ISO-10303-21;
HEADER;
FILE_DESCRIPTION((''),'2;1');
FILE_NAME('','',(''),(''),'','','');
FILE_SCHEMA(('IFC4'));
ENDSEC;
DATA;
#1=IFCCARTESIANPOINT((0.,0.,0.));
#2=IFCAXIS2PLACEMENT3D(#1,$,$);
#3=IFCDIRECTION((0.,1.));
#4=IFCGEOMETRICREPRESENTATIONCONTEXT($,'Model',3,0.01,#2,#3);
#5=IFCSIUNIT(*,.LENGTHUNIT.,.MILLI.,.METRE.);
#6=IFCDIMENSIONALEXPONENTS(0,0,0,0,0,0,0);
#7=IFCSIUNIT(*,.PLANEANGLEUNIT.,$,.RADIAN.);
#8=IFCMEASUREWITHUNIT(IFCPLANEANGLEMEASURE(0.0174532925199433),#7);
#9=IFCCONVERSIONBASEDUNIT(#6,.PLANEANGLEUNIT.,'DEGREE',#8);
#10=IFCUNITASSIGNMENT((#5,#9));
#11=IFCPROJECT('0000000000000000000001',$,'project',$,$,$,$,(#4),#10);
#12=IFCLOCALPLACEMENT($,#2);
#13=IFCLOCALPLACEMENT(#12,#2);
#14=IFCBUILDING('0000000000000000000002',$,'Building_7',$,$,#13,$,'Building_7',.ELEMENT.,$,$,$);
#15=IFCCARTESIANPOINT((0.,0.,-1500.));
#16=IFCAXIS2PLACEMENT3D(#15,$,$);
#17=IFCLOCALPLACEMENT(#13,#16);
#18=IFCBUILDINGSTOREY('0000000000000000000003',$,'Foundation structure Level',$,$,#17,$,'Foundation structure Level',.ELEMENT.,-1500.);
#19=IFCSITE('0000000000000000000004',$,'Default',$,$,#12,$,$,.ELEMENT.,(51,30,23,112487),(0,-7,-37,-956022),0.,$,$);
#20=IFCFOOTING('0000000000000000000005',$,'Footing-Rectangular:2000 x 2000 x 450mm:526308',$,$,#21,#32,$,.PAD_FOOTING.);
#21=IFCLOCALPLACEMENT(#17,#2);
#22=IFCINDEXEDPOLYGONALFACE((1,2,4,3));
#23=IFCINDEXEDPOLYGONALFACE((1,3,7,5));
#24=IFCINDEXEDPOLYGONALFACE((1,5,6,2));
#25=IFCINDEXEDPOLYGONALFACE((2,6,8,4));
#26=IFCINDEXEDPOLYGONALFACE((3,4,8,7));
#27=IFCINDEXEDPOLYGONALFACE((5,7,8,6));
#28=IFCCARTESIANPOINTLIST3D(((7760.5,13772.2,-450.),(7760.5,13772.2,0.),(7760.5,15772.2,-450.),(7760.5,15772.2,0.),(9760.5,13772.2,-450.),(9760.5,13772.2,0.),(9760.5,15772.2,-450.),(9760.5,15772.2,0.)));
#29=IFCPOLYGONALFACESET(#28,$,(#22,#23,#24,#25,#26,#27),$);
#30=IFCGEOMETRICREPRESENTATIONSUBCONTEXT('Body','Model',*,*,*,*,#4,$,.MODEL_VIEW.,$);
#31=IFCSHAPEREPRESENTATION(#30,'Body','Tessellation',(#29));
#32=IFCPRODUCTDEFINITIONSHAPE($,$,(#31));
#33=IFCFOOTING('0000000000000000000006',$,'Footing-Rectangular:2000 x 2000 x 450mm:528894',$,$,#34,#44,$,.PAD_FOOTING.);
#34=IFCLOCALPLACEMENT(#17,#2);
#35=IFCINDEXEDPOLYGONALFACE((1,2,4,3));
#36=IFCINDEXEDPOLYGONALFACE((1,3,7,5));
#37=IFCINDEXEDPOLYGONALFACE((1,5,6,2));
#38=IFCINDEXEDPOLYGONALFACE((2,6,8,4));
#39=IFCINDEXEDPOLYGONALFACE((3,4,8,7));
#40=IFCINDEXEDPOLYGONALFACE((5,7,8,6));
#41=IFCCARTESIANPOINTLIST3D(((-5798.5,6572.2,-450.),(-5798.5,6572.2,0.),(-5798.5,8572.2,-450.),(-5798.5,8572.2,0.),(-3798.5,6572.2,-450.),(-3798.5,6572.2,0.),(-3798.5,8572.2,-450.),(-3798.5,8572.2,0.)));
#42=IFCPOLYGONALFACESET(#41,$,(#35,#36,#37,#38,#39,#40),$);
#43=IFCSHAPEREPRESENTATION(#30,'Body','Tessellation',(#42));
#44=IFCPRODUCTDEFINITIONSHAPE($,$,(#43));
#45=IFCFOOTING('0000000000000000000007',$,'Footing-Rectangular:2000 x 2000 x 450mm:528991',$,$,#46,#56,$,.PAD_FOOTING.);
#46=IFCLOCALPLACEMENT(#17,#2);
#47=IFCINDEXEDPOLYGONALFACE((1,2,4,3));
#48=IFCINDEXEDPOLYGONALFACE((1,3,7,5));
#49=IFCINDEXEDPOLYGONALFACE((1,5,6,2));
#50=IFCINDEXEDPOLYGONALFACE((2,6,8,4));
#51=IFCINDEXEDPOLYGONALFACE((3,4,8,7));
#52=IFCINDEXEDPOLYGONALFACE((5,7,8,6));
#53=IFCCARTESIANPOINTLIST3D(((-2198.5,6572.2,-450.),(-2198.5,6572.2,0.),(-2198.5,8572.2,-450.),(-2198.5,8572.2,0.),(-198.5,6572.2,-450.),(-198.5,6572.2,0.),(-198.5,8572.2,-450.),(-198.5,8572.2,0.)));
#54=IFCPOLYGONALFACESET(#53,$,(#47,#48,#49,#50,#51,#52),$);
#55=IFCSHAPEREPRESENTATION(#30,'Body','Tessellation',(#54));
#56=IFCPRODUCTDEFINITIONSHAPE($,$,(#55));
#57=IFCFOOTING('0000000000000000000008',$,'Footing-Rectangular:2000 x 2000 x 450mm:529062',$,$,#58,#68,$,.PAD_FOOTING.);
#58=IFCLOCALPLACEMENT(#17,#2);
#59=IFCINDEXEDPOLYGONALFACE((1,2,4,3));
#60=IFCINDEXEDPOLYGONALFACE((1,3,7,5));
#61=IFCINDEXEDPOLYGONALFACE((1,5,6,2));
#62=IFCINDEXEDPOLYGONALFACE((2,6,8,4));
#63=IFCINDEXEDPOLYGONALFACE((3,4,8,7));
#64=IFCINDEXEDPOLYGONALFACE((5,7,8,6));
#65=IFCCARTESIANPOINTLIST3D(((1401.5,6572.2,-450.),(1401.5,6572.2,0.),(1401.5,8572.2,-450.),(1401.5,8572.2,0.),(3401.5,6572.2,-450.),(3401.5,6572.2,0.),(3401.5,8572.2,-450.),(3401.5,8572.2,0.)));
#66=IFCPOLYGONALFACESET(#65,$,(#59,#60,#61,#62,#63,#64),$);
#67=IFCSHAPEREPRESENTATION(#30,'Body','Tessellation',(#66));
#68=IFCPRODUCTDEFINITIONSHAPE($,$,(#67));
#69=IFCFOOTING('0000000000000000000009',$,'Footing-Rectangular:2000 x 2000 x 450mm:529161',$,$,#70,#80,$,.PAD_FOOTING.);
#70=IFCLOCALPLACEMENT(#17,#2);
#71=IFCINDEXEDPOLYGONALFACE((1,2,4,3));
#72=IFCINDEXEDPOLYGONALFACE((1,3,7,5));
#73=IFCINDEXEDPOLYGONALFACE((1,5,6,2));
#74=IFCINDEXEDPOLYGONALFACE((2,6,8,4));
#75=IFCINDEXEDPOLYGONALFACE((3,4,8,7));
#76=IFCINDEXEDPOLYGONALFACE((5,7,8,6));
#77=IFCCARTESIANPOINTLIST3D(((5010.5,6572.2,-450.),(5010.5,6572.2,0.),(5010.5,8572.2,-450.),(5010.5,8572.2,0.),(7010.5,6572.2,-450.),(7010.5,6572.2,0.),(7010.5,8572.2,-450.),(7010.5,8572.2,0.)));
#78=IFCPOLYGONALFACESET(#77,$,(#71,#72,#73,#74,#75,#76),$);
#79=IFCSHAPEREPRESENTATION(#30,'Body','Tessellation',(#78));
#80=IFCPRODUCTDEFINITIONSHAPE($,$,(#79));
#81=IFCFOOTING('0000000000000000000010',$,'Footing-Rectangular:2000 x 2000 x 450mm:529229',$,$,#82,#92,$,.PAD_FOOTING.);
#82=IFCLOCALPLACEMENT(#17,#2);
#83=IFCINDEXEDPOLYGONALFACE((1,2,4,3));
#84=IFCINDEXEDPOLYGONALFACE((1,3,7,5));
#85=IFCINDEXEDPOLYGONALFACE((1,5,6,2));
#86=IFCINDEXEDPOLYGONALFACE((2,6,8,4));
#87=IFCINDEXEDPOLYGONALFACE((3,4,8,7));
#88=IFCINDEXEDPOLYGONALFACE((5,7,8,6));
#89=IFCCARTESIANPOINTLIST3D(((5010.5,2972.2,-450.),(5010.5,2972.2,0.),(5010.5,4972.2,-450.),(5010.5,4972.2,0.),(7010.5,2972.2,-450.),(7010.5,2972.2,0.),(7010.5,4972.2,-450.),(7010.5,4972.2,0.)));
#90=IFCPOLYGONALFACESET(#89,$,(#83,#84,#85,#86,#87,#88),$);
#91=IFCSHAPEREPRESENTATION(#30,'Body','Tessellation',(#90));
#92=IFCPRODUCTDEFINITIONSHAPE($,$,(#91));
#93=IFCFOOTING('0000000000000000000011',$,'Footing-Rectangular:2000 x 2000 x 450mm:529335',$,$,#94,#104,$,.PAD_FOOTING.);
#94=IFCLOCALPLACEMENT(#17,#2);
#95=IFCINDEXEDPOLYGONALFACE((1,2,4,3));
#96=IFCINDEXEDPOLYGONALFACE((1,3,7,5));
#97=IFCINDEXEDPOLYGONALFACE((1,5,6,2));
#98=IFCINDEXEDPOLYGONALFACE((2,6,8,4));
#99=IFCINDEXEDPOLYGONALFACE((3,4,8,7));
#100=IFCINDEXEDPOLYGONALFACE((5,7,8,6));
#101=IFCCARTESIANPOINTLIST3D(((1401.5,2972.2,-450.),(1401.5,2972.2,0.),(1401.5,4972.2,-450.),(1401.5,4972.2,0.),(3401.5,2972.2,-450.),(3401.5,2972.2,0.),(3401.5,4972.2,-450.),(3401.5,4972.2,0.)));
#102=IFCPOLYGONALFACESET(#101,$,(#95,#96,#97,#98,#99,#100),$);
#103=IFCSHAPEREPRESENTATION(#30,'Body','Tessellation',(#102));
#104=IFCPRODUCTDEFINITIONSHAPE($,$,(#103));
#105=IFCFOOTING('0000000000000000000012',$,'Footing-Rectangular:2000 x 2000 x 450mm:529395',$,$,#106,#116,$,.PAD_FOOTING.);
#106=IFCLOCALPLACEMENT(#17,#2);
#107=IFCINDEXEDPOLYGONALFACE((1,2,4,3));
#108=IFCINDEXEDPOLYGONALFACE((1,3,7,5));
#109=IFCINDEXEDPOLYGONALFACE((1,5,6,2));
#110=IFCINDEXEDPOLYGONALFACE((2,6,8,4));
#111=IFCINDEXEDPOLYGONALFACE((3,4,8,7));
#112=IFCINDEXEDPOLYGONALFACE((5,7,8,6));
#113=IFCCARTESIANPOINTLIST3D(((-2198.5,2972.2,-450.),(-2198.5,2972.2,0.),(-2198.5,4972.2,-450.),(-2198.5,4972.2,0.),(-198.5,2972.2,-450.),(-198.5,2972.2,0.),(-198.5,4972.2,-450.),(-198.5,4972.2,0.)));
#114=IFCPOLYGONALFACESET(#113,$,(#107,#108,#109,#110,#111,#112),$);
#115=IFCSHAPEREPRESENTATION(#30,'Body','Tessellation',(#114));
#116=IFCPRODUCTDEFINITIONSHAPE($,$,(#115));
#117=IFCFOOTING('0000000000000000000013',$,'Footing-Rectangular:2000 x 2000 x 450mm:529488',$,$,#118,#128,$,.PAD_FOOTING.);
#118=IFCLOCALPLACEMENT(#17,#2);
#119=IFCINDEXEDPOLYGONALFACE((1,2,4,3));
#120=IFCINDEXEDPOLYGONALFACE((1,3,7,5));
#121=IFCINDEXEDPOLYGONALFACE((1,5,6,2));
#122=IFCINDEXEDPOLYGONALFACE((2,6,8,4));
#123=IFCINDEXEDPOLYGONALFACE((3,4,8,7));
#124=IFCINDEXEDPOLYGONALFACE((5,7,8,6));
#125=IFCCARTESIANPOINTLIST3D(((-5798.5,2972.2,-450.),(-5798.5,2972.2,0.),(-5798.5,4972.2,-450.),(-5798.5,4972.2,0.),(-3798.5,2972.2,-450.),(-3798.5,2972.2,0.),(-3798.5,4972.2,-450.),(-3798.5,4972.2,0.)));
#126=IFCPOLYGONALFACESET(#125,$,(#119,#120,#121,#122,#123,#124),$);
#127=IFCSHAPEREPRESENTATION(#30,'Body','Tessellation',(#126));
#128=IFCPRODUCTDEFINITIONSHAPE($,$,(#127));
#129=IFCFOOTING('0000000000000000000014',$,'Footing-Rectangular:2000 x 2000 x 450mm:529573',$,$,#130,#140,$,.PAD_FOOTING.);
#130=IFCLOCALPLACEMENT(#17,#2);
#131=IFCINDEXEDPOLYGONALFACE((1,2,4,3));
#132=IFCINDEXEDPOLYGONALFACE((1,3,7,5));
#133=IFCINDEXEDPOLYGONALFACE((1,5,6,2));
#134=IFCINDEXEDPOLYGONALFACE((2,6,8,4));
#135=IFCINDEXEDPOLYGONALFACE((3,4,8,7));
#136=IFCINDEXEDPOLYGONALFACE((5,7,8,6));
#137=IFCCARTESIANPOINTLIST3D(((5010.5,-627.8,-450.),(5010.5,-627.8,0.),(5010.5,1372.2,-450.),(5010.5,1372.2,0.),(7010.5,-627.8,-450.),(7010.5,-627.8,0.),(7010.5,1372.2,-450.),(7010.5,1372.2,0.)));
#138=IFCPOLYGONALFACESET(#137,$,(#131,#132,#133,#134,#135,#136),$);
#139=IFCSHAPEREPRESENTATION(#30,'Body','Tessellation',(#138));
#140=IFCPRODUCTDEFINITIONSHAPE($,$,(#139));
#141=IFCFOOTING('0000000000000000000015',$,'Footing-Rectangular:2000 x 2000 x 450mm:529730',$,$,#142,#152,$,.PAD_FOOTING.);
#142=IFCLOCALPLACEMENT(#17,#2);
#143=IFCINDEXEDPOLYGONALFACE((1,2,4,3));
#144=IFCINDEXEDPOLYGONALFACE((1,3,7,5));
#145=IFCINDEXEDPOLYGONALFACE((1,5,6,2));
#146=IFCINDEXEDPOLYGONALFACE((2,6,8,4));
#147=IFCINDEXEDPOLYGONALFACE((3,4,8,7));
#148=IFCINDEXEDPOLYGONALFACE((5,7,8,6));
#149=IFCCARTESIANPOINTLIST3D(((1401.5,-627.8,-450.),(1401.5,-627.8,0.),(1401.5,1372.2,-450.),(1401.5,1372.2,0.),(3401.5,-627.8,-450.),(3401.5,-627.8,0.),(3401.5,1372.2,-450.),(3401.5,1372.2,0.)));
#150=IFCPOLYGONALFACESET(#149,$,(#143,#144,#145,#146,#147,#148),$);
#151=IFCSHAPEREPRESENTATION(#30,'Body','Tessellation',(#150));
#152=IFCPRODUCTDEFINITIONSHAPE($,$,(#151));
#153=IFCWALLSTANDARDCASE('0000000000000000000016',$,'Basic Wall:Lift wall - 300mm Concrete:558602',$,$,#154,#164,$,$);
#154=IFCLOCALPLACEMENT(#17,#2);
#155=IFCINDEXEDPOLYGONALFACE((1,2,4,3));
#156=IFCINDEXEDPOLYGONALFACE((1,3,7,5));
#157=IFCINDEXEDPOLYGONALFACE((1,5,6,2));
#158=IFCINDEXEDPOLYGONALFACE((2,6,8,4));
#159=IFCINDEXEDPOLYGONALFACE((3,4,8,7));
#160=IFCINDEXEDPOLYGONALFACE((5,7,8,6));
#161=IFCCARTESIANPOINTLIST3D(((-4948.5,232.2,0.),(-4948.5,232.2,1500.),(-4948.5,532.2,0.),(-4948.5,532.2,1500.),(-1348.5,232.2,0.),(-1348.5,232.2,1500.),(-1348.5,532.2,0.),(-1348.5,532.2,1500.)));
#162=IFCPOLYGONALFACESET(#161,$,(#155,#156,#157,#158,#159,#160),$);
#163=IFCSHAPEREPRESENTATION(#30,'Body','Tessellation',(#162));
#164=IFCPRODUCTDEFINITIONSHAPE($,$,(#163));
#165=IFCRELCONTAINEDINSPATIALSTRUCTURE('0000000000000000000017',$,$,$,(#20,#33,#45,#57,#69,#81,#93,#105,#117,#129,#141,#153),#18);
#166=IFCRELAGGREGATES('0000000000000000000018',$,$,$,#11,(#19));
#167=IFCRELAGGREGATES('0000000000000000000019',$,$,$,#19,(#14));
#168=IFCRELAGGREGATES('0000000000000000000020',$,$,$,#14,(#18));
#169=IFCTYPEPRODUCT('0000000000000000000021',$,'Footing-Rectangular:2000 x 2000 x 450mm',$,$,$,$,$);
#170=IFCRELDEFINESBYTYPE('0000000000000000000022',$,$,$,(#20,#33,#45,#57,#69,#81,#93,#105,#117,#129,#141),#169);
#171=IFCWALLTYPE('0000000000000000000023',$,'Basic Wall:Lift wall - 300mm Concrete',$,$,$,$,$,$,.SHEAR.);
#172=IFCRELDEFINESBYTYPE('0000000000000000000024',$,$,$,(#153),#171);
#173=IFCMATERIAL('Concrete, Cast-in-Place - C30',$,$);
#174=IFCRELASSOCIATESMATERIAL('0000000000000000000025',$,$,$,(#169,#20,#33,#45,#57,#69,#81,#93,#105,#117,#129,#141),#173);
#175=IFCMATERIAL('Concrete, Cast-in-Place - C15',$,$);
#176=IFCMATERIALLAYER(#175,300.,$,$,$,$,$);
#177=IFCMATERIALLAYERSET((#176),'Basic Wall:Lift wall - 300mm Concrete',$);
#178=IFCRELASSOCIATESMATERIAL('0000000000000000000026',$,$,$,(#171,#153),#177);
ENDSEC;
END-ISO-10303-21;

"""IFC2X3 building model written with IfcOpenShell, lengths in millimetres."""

from ifc_helpers import new_model, entity, si_unit, converted_unit, direction, frame, frame_2d, origin, origin_2d_with_axis, place, context, subcontext, project, spatial, rectangle, extrude, source, transform, mapped, material, layer, layer_set, layer_usage, type_object, type_shapes, element, save


model = new_model("IFC2X3")

# Units and contexts
model_context = context("Model", 3, precision=0.01, world=origin(), true_north=direction((0.0, 1.0)))
body_context = subcontext(model_context, "Body", "Model", "MODEL_VIEW")
ifc_project = project(units=[si_unit("LENGTHUNIT", "METRE", prefix="MILLI"), converted_unit("PLANEANGLEUNIT", "DEGREE", entity("IfcPlaneAngleMeasure", 0.0174532925199433), si_unit("PLANEANGLEUNIT", "RADIAN"), dimensions=[0, 0, 0, 0, 0, 0, 0])], contexts=[model_context])

# Site, building, storey
site_placement = place(None, origin())
site = spatial("IfcSite", under=ifc_project, at=site_placement, Name="Default", CompositionType="ELEMENT", RefLatitude=(51, 30, 23, 112487), RefLongitude=(0, -7, -37, -956022), RefElevation=0.0)
building_placement = place(site_placement, origin())
building = spatial("IfcBuilding", under=site, at=building_placement, Name="Building_7", LongName="Building_7", CompositionType="ELEMENT")
storey_placement = place(building_placement, frame((0.0, 0.0, -1500.0)))
storey = spatial("IfcBuildingStorey", under=building, at=storey_placement, Name="Foundation structure Level", LongName="Foundation structure Level", CompositionType="ELEMENT", Elevation=-1500.0)

# Footings
ifc_material_1 = material(Name="Concrete, Cast-in-Place - C30")
type_product = type_object("IfcTypeProduct", Name="Footing-Rectangular:2000 x 2000 x 450mm", material=ifc_material_1)
shared_shape = source(origin(), body_context, "Body", "SweptSolid", [
    extrude(rectangle(XDim=2000.0, YDim=2000.0, at=origin_2d_with_axis()), frame((0.0, 0.0, -450.0), z_axis=(0.0, 0.0, 1.0), x_axis=(-1.0, 0.0, 0.0)), (0.0, 0.0, 1.0), 450.0),
])
type_shapes(type_product, [shared_shape])
for number, where, name in (
    (1, (8760.5, 14772.2, 0.0), "Footing-Rectangular:2000 x 2000 x 450mm:526308"),
    (2, (-4798.5, 7572.2, 0.0), "Footing-Rectangular:2000 x 2000 x 450mm:528894"),
    (3, (-1198.5, 7572.2, 0.0), "Footing-Rectangular:2000 x 2000 x 450mm:528991"),
    (4, (2401.5, 7572.2, 0.0), "Footing-Rectangular:2000 x 2000 x 450mm:529062"),
    (5, (6010.5, 7572.2, 0.0), "Footing-Rectangular:2000 x 2000 x 450mm:529161"),
    (6, (6010.5, 3972.2, 0.0), "Footing-Rectangular:2000 x 2000 x 450mm:529229"),
    (7, (2401.5, 3972.2, 0.0), "Footing-Rectangular:2000 x 2000 x 450mm:529335"),
    (8, (-1198.5, 3972.2, 0.0), "Footing-Rectangular:2000 x 2000 x 450mm:529395"),
    (9, (-4798.5, 3972.2, 0.0), "Footing-Rectangular:2000 x 2000 x 450mm:529488"),
    (10, (6010.5, 372.2, 0.0), "Footing-Rectangular:2000 x 2000 x 450mm:529573"),
    (11, (2401.5, 372.2, 0.0), "Footing-Rectangular:2000 x 2000 x 450mm:529730"),
):
    element("IfcFooting", number, at=place(storey_placement, frame(where)), inside=storey, type_object=type_product, material=ifc_material_1, Name=name, PredefinedType="PAD_FOOTING", context=body_context, shape_type="MappedRepresentation", body=[
        mapped(shared_shape, transform((0.0, 0.0, 0.0), scale=1.0)),
    ])

# Wall
ifc_material_2 = material(Name="Concrete, Cast-in-Place - C15")
ifc_layer = layer(ifc_material_2, 300.0)
ifc_layer_set = layer_set([ifc_layer], Name="Basic Wall:Lift wall - 300mm Concrete")
ifc_layer_usage = layer_usage(ifc_layer_set, "AXIS2", "NEGATIVE", 150.0)
wall_type = type_object("IfcWallType", Name="Basic Wall:Lift wall - 300mm Concrete", PredefinedType="SHEAR", material=ifc_layer_set)
wall_placement = place(storey_placement, frame((-1348.5, 382.2, 0.0), z_axis=(0.0, 0.0, 1.0), x_axis=(-1.0, 0.0, 0.0)))
element("IfcWallStandardCase", 12, at=wall_placement, inside=storey, type_object=wall_type, material=ifc_layer_usage, Name="Basic Wall:Lift wall - 300mm Concrete:558602", context=body_context, shape_type="SweptSolid", body=[
    extrude(rectangle(XDim=3600.0, YDim=300.0, at=frame_2d((1800.0, 0.0), x_axis=(-1.0, 0.0))), origin(), (0.0, 0.0, 1.0), 1500.0),
])

save(model, "model.ifc")
